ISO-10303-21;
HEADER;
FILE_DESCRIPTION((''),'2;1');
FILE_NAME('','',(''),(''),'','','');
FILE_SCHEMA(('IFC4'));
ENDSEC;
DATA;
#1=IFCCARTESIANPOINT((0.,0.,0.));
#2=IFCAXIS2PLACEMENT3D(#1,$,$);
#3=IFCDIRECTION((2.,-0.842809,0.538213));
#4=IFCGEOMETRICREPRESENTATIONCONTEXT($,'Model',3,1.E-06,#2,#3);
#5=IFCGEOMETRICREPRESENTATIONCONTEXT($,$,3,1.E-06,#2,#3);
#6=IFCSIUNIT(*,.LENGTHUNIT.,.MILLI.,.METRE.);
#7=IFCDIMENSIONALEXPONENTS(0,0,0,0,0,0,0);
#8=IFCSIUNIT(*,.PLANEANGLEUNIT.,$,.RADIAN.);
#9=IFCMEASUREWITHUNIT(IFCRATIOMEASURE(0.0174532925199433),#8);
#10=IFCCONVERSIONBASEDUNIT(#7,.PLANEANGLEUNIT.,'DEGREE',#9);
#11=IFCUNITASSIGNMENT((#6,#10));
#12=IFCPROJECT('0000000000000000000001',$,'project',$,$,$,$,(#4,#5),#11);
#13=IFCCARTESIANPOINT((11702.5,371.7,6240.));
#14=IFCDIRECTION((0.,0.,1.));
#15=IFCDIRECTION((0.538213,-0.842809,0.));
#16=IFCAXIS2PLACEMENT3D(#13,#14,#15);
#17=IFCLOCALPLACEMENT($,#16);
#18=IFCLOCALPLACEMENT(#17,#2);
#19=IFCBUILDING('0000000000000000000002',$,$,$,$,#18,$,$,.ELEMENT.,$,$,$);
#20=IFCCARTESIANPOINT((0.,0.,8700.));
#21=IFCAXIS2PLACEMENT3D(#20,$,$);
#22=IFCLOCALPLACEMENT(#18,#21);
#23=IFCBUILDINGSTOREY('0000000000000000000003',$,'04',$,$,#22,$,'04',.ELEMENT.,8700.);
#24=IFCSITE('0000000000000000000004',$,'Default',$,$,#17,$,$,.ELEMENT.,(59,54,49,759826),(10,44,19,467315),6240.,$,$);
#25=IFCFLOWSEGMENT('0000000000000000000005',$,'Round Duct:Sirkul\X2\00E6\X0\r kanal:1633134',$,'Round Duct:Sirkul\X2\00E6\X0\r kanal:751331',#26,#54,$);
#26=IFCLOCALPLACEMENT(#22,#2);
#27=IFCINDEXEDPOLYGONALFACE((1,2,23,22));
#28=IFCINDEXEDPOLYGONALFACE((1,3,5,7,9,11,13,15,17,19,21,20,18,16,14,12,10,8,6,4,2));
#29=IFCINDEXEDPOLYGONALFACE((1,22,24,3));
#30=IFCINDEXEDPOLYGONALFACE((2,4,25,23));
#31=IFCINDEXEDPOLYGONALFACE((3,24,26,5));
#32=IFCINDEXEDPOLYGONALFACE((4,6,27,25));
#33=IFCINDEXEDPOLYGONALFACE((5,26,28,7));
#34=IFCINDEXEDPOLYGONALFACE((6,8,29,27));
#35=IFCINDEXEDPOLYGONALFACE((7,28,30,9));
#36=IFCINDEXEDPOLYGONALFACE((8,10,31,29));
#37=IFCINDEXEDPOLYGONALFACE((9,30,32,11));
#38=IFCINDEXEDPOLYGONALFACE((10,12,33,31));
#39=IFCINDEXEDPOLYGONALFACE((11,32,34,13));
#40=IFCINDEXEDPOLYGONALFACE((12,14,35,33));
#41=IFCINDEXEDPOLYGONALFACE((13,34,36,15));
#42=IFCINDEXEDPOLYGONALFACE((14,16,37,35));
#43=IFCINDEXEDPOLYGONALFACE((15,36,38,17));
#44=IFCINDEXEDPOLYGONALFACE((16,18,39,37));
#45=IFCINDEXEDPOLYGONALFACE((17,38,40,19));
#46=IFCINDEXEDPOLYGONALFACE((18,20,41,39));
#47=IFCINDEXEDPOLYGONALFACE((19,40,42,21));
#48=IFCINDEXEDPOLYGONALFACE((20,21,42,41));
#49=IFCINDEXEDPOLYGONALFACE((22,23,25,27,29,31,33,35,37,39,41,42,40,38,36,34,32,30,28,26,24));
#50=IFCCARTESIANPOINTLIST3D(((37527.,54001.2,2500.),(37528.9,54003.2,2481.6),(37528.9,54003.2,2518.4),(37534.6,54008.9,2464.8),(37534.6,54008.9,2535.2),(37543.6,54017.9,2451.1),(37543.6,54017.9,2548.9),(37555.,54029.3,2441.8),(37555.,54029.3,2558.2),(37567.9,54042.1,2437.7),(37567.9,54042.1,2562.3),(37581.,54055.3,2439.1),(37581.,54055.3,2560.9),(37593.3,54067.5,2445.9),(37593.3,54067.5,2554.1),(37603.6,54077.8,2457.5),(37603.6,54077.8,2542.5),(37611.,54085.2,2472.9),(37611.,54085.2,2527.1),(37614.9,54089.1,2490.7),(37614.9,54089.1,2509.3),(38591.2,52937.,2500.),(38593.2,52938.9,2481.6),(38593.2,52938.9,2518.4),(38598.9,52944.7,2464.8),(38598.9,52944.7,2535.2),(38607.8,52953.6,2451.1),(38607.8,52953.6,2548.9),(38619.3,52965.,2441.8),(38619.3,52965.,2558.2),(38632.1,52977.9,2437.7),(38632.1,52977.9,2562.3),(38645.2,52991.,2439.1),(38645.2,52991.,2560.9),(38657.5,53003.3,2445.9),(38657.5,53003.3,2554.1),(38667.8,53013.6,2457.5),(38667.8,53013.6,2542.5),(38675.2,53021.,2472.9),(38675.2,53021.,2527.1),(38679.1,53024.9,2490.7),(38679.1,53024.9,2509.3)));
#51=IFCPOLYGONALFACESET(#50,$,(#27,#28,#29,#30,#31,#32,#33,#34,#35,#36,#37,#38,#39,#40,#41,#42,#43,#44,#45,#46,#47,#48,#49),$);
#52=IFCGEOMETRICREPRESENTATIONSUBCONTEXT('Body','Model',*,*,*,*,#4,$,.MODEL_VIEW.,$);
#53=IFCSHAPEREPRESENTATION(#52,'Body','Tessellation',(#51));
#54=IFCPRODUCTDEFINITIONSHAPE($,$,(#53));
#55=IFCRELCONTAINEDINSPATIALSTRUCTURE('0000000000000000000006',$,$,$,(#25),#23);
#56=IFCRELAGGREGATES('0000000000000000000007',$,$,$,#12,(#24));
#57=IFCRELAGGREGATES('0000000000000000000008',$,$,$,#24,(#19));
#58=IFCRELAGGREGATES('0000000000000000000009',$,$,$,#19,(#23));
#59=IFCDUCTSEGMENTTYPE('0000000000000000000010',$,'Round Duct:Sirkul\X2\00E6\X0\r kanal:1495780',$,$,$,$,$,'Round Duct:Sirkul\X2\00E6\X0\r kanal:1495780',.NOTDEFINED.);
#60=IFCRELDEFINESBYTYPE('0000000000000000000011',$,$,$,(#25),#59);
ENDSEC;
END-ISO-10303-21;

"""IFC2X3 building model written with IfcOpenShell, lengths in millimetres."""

from ifc_helpers import new_model, entity, si_unit, converted_unit, direction, frame, origin, origin_2d_with_axis, place, context, subcontext, project, spatial, circle, extrude, type_object, element, save


model = new_model("IFC2X3")

# Units and contexts
model_context = context("Model", 3, precision=1e-06, world=origin(), true_north=direction((2.0, -0.842809, 0.538213)))
context_of_model = context(None, 3, precision=1e-06, world=origin(), true_north=direction((2.0, -0.842809, 0.538213)))
body_context = subcontext(model_context, "Body", "Model", "MODEL_VIEW")
ifc_project = project(units=[si_unit("LENGTHUNIT", "METRE", prefix="MILLI"), converted_unit("PLANEANGLEUNIT", "DEGREE", entity("IfcRatioMeasure", 0.0174532925199433), si_unit("PLANEANGLEUNIT", "RADIAN"), dimensions=[0, 0, 0, 0, 0, 0, 0])], contexts=[model_context, context_of_model])

# Site, building, storey
site_placement = place(None, frame((11702.5, 371.7, 6240.0), z_axis=(0.0, 0.0, 1.0), x_axis=(0.538213, -0.842809, 0.0)))
site = spatial("IfcSite", under=ifc_project, at=site_placement, Name="Default", CompositionType="ELEMENT", RefLatitude=(59, 54, 49, 759826), RefLongitude=(10, 44, 19, 467315), RefElevation=6240.0)
building_placement = place(site_placement, origin())
building = spatial("IfcBuilding", under=site, at=building_placement, CompositionType="ELEMENT")
storey_placement = place(building_placement, frame((0.0, 0.0, 8700.0)))
storey = spatial("IfcBuildingStorey", under=building, at=storey_placement, Name="04", LongName="04", CompositionType="ELEMENT", Elevation=8700.0)

# Flow segment
duct_segment_type = type_object("IfcDuctSegmentType", Name="Round Duct:Sirkulær kanal:1495780", ElementType="Round Duct:Sirkulær kanal:1495780", PredefinedType="NOTDEFINED")
flow_segment_1_placement = place(building_placement, frame((0.0, 0.0, 8700.0)))
element("IfcFlowSegment", 1, at=flow_segment_1_placement, inside=storey, type_object=duct_segment_type, Name="Round Duct:Sirkulær kanal:1633134", ObjectType="Round Duct:Sirkulær kanal:751331", context=body_context, shape_type="SweptSolid", body=[
    extrude(circle(Radius=62.5, at=origin_2d_with_axis()), frame((37571.2, 54045.4, 2500.0), z_axis=(0.707107, -0.707107, 0.0), x_axis=(-0.707107, -0.707107, 0.0)), (0.0, 0.0, 1.0), 1505.1),
])

save(model, "model.ifc")
